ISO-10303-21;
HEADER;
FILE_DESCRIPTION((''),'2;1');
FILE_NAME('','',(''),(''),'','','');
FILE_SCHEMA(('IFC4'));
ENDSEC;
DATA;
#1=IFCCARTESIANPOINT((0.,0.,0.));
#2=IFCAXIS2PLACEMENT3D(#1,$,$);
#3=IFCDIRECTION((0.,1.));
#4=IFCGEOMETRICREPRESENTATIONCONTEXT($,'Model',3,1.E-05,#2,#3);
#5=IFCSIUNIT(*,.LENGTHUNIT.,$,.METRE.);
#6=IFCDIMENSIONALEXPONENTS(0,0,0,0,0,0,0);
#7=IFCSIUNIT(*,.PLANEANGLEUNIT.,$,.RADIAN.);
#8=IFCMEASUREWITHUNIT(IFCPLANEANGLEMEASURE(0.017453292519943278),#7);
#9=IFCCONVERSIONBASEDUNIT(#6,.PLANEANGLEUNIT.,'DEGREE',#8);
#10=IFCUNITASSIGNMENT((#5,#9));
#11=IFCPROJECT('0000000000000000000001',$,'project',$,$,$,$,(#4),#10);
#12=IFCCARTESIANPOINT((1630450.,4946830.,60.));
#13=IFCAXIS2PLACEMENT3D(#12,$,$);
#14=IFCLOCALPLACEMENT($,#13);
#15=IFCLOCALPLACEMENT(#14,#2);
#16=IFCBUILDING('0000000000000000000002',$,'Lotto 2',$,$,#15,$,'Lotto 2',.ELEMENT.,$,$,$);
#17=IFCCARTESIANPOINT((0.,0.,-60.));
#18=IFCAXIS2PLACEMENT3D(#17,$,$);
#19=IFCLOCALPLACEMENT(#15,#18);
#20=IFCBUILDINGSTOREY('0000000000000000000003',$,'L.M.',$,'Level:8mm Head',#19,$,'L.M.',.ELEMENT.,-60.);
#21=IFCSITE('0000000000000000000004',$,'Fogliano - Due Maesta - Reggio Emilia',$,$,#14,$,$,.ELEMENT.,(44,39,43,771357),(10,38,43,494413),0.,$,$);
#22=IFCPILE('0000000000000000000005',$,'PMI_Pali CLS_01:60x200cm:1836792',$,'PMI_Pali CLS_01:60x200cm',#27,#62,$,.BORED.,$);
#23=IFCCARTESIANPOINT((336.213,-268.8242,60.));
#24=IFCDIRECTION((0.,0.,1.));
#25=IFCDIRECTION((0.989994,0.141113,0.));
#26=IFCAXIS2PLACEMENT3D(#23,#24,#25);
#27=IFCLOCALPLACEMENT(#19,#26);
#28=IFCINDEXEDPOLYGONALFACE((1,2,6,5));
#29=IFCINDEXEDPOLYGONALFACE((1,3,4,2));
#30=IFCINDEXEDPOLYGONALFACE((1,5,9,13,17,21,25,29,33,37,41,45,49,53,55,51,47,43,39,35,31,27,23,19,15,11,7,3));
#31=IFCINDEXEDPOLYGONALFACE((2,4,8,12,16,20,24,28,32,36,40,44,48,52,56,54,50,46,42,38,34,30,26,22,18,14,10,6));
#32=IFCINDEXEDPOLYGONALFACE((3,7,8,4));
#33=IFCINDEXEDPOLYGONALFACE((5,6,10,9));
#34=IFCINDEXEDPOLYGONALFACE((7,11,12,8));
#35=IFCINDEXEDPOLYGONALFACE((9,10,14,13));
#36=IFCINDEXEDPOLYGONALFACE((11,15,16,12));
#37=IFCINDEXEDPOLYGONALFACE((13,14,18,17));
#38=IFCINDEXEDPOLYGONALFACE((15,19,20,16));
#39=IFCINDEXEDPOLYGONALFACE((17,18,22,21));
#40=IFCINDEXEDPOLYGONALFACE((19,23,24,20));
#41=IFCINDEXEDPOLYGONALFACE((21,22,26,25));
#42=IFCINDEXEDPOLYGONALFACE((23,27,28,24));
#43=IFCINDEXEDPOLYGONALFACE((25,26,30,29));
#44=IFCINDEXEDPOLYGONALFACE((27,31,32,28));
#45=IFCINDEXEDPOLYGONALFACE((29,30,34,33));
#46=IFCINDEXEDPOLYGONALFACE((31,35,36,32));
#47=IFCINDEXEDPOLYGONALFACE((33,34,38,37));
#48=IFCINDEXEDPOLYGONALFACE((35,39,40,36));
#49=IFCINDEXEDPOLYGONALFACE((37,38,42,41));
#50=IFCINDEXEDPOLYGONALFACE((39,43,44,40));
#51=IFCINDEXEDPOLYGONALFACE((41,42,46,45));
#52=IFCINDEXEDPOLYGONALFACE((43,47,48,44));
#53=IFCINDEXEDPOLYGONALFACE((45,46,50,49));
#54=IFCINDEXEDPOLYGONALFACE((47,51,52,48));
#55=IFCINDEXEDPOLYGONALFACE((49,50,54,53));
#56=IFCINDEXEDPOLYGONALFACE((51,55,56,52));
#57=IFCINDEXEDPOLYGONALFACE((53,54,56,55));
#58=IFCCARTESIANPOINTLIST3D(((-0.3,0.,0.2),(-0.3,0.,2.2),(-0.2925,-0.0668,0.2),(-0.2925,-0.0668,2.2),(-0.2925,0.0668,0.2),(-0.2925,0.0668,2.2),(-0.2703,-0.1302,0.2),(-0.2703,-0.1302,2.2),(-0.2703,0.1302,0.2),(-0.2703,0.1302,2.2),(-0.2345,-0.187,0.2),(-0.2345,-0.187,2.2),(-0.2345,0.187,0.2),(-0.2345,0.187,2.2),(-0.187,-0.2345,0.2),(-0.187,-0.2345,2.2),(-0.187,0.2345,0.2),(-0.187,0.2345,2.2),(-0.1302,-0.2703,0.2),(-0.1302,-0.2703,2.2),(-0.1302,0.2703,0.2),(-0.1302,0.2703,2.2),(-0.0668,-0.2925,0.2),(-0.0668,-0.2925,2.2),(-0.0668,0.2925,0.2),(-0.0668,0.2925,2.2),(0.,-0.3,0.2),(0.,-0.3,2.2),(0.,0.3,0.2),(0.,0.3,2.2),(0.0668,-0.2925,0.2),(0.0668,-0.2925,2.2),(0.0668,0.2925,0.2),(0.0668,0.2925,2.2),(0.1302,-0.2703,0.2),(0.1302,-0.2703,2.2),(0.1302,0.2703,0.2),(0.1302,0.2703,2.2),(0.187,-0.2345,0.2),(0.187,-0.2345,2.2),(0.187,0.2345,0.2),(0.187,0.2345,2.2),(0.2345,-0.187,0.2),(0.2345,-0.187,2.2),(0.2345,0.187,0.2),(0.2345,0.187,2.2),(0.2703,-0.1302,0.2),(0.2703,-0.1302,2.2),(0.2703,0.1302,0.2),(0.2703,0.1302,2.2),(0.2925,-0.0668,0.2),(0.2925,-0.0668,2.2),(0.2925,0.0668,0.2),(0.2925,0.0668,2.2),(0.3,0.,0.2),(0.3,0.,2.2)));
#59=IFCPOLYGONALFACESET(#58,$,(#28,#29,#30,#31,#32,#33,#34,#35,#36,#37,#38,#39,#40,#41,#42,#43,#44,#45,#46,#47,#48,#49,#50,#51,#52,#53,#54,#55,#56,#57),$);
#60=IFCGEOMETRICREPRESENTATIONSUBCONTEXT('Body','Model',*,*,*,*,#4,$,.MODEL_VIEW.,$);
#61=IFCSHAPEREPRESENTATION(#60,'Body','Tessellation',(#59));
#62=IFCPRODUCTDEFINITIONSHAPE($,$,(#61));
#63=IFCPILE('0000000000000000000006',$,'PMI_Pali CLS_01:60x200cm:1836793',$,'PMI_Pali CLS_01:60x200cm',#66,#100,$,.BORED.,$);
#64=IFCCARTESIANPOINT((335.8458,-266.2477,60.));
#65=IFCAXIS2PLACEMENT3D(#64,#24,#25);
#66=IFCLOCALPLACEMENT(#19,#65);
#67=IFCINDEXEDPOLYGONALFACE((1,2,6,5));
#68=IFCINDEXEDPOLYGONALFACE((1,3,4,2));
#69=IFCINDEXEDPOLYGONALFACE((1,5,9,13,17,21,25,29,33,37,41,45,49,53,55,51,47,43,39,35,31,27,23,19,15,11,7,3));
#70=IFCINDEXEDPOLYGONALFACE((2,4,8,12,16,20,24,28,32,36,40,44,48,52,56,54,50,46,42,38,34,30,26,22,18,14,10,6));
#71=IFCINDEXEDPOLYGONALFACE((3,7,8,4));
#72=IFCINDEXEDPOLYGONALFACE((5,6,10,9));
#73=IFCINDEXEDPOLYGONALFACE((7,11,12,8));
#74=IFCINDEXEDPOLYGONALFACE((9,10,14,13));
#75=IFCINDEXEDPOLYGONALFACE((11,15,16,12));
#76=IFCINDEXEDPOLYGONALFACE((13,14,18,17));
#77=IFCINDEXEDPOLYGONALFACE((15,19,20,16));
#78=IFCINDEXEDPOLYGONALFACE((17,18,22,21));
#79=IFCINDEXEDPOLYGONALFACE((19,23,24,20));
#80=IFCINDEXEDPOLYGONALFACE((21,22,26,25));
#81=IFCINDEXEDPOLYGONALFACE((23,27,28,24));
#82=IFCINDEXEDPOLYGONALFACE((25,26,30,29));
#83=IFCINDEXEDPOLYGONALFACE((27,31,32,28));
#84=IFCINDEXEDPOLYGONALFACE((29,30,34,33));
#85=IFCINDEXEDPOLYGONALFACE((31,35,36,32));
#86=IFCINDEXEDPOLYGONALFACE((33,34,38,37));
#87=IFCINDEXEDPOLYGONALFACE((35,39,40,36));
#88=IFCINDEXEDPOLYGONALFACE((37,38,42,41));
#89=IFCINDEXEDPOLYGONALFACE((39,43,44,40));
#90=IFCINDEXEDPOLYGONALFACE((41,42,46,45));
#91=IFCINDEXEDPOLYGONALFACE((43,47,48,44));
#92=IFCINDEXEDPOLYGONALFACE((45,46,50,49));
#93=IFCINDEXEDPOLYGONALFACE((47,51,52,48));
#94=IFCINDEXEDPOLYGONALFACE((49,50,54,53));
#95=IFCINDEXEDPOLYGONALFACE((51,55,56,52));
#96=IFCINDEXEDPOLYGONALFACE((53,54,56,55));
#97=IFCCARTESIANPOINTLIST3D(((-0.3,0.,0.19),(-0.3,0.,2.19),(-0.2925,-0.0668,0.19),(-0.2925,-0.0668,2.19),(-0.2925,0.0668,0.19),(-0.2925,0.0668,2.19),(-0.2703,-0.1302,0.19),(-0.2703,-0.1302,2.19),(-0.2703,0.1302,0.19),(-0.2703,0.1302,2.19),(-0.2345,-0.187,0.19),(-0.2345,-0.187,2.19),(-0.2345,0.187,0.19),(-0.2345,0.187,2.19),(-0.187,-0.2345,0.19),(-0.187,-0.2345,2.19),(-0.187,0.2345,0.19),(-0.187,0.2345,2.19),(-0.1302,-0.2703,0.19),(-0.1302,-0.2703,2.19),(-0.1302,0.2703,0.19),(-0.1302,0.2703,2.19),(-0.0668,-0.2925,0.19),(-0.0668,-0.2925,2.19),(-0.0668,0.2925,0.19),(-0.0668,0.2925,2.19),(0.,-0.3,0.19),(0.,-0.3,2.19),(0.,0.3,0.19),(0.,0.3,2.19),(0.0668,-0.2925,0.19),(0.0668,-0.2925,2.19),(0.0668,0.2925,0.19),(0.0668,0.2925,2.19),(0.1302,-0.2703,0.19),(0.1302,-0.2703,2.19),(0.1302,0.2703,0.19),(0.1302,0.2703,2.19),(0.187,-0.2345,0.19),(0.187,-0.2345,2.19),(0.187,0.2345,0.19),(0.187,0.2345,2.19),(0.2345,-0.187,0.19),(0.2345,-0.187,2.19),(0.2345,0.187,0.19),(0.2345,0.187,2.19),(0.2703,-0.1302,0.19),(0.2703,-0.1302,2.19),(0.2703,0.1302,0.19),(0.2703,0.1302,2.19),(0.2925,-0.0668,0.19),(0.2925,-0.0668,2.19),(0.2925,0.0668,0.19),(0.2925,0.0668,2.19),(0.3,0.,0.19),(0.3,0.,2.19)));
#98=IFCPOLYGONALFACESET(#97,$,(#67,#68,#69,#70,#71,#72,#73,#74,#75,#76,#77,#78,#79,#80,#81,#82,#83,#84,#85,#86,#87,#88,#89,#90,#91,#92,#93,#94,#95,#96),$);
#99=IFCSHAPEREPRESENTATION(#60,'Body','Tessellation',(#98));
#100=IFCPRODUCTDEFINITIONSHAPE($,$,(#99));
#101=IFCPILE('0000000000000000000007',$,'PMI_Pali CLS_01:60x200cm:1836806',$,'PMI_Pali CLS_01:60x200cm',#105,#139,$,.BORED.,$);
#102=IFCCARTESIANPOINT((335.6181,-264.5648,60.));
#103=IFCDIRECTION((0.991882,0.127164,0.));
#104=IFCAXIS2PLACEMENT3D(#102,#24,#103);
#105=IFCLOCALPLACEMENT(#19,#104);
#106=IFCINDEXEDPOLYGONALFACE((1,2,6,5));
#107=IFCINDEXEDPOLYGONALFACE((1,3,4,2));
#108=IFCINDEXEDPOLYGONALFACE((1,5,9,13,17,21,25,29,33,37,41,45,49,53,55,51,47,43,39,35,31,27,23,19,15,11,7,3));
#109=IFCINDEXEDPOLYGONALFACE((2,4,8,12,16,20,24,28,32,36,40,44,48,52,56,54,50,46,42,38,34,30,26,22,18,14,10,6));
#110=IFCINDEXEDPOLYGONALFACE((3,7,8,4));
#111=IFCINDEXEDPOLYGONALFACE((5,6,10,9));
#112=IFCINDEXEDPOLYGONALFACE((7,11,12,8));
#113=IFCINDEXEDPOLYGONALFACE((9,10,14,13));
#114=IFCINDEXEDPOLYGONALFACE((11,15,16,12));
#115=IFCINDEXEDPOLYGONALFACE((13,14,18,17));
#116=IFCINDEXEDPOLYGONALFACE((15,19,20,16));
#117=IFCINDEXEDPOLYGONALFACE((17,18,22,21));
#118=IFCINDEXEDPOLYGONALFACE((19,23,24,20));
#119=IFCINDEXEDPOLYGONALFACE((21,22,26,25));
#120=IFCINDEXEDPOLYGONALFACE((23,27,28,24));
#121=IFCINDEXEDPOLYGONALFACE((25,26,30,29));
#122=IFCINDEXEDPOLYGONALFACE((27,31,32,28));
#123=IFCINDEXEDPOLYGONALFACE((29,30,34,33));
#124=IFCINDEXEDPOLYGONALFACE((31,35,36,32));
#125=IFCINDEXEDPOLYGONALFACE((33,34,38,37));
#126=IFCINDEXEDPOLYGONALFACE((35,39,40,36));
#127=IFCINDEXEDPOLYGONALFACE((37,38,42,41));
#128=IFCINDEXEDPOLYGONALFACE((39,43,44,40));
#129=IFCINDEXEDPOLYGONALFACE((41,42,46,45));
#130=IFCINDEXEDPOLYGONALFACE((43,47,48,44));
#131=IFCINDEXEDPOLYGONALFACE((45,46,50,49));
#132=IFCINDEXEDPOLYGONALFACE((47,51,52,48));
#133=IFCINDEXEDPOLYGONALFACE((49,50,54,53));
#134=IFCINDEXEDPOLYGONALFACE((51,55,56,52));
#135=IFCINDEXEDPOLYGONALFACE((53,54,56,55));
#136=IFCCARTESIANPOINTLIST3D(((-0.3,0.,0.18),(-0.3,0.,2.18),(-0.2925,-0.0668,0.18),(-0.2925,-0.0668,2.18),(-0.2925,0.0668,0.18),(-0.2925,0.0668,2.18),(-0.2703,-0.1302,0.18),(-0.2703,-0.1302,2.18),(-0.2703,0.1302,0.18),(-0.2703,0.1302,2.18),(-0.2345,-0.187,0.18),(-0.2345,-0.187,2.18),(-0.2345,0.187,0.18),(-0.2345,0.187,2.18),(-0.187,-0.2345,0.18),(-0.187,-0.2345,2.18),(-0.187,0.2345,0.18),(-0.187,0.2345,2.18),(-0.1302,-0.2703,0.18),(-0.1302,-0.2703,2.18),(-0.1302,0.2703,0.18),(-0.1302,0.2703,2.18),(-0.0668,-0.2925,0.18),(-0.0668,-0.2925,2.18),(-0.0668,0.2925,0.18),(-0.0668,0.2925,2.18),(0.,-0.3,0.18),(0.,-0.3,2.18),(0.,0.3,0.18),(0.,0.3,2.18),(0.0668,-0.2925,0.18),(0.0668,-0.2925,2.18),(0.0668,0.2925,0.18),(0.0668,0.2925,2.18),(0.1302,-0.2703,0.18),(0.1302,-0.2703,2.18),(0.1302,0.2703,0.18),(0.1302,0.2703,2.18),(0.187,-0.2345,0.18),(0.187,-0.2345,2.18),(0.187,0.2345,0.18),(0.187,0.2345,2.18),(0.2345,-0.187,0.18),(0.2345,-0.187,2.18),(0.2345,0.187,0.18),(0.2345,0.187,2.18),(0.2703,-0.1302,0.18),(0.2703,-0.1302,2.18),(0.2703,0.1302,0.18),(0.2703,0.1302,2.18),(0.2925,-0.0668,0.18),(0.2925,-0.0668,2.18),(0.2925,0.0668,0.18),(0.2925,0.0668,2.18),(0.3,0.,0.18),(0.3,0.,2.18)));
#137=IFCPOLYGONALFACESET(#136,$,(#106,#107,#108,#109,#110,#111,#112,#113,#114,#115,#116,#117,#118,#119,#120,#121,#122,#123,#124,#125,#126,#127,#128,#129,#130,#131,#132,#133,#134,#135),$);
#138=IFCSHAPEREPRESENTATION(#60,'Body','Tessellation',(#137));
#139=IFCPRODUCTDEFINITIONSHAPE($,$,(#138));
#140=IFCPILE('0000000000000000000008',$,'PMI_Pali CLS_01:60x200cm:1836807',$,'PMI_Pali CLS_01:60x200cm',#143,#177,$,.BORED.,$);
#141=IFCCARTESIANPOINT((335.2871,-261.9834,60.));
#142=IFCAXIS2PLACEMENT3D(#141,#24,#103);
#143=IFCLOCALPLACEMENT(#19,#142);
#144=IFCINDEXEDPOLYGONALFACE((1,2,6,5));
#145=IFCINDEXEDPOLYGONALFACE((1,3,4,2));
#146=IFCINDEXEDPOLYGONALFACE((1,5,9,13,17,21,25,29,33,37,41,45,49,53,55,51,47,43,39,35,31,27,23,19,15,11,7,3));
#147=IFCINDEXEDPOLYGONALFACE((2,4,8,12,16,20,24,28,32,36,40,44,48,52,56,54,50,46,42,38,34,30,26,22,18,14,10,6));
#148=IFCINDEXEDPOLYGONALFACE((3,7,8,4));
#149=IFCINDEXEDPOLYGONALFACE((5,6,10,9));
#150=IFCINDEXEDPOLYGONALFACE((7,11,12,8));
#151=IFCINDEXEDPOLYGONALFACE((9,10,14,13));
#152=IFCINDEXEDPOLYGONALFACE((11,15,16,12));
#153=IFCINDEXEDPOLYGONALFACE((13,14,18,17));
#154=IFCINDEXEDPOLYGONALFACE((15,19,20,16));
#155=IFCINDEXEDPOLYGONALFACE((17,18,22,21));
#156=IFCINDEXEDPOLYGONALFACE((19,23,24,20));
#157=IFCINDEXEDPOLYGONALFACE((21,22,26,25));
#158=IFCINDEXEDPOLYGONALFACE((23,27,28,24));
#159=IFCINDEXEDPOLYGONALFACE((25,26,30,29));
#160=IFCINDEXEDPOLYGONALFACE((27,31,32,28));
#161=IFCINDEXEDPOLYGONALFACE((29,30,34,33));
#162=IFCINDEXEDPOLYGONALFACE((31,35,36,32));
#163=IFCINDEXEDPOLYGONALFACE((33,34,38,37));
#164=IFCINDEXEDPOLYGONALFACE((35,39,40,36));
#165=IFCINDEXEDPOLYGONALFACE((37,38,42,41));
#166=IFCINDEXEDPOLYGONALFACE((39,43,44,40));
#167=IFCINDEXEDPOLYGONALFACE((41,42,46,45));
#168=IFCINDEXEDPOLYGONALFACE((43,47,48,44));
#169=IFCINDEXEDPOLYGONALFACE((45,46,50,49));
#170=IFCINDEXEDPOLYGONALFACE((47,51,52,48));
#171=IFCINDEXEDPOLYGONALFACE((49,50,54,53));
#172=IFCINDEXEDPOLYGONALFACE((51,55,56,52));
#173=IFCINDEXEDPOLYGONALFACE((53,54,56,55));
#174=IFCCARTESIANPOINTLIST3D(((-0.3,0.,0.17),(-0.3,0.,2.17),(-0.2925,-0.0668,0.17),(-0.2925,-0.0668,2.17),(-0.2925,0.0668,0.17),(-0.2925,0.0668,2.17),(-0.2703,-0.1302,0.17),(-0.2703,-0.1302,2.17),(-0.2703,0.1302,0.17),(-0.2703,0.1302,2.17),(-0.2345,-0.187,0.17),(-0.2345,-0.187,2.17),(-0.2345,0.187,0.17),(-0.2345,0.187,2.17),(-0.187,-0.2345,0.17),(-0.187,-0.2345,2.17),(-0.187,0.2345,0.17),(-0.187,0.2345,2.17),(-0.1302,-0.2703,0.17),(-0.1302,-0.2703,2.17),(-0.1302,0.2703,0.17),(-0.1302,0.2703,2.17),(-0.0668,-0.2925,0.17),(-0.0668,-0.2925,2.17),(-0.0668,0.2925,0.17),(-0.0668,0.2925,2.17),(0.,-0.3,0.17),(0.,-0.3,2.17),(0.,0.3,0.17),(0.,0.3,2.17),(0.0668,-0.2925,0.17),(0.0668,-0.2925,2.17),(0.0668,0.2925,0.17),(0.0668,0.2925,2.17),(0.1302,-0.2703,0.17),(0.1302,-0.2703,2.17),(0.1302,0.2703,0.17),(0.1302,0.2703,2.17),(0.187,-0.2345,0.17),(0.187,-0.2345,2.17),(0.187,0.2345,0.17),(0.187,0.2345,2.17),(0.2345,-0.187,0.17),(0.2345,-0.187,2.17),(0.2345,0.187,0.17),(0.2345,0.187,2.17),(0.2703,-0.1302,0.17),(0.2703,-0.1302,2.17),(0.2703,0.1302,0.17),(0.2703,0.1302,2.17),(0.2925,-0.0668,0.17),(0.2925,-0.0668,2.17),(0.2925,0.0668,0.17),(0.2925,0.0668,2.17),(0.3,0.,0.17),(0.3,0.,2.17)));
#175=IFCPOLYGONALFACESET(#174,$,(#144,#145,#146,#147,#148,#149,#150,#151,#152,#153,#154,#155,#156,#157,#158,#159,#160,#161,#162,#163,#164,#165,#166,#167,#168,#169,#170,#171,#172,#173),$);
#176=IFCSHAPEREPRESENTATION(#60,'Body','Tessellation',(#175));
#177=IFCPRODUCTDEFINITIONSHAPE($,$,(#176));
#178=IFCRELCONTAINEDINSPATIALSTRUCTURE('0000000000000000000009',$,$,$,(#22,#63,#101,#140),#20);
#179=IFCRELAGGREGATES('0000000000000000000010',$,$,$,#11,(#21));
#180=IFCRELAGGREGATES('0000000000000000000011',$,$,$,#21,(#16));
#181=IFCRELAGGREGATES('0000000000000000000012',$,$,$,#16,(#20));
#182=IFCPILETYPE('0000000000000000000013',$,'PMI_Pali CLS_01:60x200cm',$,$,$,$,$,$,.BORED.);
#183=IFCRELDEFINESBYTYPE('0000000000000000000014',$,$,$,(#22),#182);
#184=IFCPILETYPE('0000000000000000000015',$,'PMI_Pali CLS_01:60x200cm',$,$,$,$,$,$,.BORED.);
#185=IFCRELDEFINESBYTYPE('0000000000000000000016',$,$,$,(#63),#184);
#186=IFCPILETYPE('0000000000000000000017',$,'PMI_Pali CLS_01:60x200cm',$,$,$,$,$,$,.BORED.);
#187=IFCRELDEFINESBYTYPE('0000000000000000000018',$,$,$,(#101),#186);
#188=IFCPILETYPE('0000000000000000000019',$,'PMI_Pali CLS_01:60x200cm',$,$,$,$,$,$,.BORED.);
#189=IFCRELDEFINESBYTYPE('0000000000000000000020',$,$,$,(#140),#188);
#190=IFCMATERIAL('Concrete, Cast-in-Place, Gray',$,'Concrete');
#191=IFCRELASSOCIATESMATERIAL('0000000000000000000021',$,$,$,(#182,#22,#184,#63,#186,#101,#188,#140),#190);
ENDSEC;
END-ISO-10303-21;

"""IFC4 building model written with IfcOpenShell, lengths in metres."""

from ifc_helpers import new_model, entity, si_unit, converted_unit, direction, frame, origin, place, context, subcontext, project, spatial, arc, indexed_curve, outline, extrude, source, transform, mapped, material, type_object, type_shapes, element, save


model = new_model("IFC4")

# Units and contexts
model_context = context("Model", 3, precision=1e-05, world=origin(), true_north=direction((0.0, 1.0)))
body_context = subcontext(model_context, "Body", "Model", "MODEL_VIEW")
ifc_project = project(units=[si_unit("LENGTHUNIT", "METRE"), converted_unit("PLANEANGLEUNIT", "DEGREE", entity("IfcPlaneAngleMeasure", 0.017453292519943278), si_unit("PLANEANGLEUNIT", "RADIAN"), dimensions=[0, 0, 0, 0, 0, 0, 0])], contexts=[model_context])

# Site, building, storey
site_placement = place(None, frame((1630450.0, 4946830.0, 60.0)))
site = spatial("IfcSite", under=ifc_project, at=site_placement, Name="Fogliano - Due Maesta - Reggio Emilia", CompositionType="ELEMENT", RefLatitude=(44, 39, 43, 771357), RefLongitude=(10, 38, 43, 494413), RefElevation=0.0)
building_placement = place(site_placement, origin())
building = spatial("IfcBuilding", under=site, at=building_placement, Name="Lotto 2", LongName="Lotto 2", CompositionType="ELEMENT")
storey_placement = place(building_placement, frame((0.0, 0.0, -60.0)))
storey = spatial("IfcBuildingStorey", under=building, at=storey_placement, Name="L.M.", ObjectType="Level:8mm Head", LongName="L.M.", CompositionType="ELEMENT", Elevation=-60.0)

# Piles
ifc_material_1 = material(Name="Concrete, Cast-in-Place, Gray", Category="Concrete")
pile_type_1 = type_object("IfcPileType", Name="PMI_Pali CLS_01:60x200cm", PredefinedType="BORED", material=ifc_material_1)
shared_shape_1 = source(origin(), body_context, "Body", "SweptSolid", [
    extrude(outline(indexed_curve([(-0.3, 0.0), (0.0, -0.3), (0.3, 0.0), (0.0, 0.3)], segments=[arc(1, 2, 3), arc(3, 4, 1)], self_intersect=False)), frame((0.0, 0.0, 0.2)), (0.0, 0.0, 1.0), 2.0),
])
type_shapes(pile_type_1, [shared_shape_1])
pile_1_placement = place(storey_placement, frame((336.213, -268.8242, 60.0), z_axis=(0.0, 0.0, 1.0), x_axis=(0.989994, 0.141113, 0.0)))
element("IfcPile", 1, at=pile_1_placement, inside=storey, type_object=pile_type_1, material=ifc_material_1, Name="PMI_Pali CLS_01:60x200cm:1836792", ObjectType="PMI_Pali CLS_01:60x200cm", PredefinedType="BORED", context=body_context, shape_type="MappedRepresentation", body=[
    mapped(shared_shape_1, transform((0.0, 0.0, 0.0), scale=1.0)),
])
pile_type_2 = type_object("IfcPileType", Name="PMI_Pali CLS_01:60x200cm", PredefinedType="BORED", material=ifc_material_1)
shared_shape_2 = source(origin(), body_context, "Body", "SweptSolid", [
    extrude(outline(indexed_curve([(-0.3, 0.0), (0.0, -0.3), (0.3, 0.0), (0.0, 0.3)], segments=[arc(1, 2, 3), arc(3, 4, 1)], self_intersect=False)), frame((0.0, 0.0, 0.19)), (0.0, 0.0, 1.0), 2.0),
])
type_shapes(pile_type_2, [shared_shape_2])
pile_2_placement = place(storey_placement, frame((335.8458, -266.2477, 60.0), z_axis=(0.0, 0.0, 1.0), x_axis=(0.989994, 0.141113, 0.0)))
element("IfcPile", 2, at=pile_2_placement, inside=storey, type_object=pile_type_2, material=ifc_material_1, Name="PMI_Pali CLS_01:60x200cm:1836793", ObjectType="PMI_Pali CLS_01:60x200cm", PredefinedType="BORED", context=body_context, shape_type="MappedRepresentation", body=[
    mapped(shared_shape_2, transform((0.0, 0.0, 0.0), scale=1.0)),
])
pile_type_3 = type_object("IfcPileType", Name="PMI_Pali CLS_01:60x200cm", PredefinedType="BORED", material=ifc_material_1)
shared_shape_3 = source(origin(), body_context, "Body", "SweptSolid", [
    extrude(outline(indexed_curve([(-0.3, 0.0), (0.0, -0.3), (0.3, 0.0), (0.0, 0.3)], segments=[arc(1, 2, 3), arc(3, 4, 1)], self_intersect=False)), frame((0.0, 0.0, 0.18)), (0.0, 0.0, 1.0), 2.0),
])
type_shapes(pile_type_3, [shared_shape_3])
pile_3_placement = place(storey_placement, frame((335.6181, -264.5648, 60.0), z_axis=(0.0, 0.0, 1.0), x_axis=(0.991882, 0.127164, 0.0)))
element("IfcPile", 3, at=pile_3_placement, inside=storey, type_object=pile_type_3, material=ifc_material_1, Name="PMI_Pali CLS_01:60x200cm:1836806", ObjectType="PMI_Pali CLS_01:60x200cm", PredefinedType="BORED", context=body_context, shape_type="MappedRepresentation", body=[
    mapped(shared_shape_3, transform((0.0, 0.0, 0.0), scale=1.0)),
])
pile_type_4 = type_object("IfcPileType", Name="PMI_Pali CLS_01:60x200cm", PredefinedType="BORED", material=ifc_material_1)
shared_shape_4 = source(origin(), body_context, "Body", "SweptSolid", [
    extrude(outline(indexed_curve([(-0.3, 0.0), (0.0, -0.3), (0.3, 0.0), (0.0, 0.3)], segments=[arc(1, 2, 3), arc(3, 4, 1)], self_intersect=False)), frame((0.0, 0.0, 0.17)), (0.0, 0.0, 1.0), 2.0),
])
type_shapes(pile_type_4, [shared_shape_4])
pile_4_placement = place(storey_placement, frame((335.2871, -261.9834, 60.0), z_axis=(0.0, 0.0, 1.0), x_axis=(0.991882, 0.127164, 0.0)))
element("IfcPile", 4, at=pile_4_placement, inside=storey, type_object=pile_type_4, material=ifc_material_1, Name="PMI_Pali CLS_01:60x200cm:1836807", ObjectType="PMI_Pali CLS_01:60x200cm", PredefinedType="BORED", context=body_context, shape_type="MappedRepresentation", body=[
    mapped(shared_shape_4, transform((0.0, 0.0, 0.0), scale=1.0)),
])

save(model, "model.ifc")
